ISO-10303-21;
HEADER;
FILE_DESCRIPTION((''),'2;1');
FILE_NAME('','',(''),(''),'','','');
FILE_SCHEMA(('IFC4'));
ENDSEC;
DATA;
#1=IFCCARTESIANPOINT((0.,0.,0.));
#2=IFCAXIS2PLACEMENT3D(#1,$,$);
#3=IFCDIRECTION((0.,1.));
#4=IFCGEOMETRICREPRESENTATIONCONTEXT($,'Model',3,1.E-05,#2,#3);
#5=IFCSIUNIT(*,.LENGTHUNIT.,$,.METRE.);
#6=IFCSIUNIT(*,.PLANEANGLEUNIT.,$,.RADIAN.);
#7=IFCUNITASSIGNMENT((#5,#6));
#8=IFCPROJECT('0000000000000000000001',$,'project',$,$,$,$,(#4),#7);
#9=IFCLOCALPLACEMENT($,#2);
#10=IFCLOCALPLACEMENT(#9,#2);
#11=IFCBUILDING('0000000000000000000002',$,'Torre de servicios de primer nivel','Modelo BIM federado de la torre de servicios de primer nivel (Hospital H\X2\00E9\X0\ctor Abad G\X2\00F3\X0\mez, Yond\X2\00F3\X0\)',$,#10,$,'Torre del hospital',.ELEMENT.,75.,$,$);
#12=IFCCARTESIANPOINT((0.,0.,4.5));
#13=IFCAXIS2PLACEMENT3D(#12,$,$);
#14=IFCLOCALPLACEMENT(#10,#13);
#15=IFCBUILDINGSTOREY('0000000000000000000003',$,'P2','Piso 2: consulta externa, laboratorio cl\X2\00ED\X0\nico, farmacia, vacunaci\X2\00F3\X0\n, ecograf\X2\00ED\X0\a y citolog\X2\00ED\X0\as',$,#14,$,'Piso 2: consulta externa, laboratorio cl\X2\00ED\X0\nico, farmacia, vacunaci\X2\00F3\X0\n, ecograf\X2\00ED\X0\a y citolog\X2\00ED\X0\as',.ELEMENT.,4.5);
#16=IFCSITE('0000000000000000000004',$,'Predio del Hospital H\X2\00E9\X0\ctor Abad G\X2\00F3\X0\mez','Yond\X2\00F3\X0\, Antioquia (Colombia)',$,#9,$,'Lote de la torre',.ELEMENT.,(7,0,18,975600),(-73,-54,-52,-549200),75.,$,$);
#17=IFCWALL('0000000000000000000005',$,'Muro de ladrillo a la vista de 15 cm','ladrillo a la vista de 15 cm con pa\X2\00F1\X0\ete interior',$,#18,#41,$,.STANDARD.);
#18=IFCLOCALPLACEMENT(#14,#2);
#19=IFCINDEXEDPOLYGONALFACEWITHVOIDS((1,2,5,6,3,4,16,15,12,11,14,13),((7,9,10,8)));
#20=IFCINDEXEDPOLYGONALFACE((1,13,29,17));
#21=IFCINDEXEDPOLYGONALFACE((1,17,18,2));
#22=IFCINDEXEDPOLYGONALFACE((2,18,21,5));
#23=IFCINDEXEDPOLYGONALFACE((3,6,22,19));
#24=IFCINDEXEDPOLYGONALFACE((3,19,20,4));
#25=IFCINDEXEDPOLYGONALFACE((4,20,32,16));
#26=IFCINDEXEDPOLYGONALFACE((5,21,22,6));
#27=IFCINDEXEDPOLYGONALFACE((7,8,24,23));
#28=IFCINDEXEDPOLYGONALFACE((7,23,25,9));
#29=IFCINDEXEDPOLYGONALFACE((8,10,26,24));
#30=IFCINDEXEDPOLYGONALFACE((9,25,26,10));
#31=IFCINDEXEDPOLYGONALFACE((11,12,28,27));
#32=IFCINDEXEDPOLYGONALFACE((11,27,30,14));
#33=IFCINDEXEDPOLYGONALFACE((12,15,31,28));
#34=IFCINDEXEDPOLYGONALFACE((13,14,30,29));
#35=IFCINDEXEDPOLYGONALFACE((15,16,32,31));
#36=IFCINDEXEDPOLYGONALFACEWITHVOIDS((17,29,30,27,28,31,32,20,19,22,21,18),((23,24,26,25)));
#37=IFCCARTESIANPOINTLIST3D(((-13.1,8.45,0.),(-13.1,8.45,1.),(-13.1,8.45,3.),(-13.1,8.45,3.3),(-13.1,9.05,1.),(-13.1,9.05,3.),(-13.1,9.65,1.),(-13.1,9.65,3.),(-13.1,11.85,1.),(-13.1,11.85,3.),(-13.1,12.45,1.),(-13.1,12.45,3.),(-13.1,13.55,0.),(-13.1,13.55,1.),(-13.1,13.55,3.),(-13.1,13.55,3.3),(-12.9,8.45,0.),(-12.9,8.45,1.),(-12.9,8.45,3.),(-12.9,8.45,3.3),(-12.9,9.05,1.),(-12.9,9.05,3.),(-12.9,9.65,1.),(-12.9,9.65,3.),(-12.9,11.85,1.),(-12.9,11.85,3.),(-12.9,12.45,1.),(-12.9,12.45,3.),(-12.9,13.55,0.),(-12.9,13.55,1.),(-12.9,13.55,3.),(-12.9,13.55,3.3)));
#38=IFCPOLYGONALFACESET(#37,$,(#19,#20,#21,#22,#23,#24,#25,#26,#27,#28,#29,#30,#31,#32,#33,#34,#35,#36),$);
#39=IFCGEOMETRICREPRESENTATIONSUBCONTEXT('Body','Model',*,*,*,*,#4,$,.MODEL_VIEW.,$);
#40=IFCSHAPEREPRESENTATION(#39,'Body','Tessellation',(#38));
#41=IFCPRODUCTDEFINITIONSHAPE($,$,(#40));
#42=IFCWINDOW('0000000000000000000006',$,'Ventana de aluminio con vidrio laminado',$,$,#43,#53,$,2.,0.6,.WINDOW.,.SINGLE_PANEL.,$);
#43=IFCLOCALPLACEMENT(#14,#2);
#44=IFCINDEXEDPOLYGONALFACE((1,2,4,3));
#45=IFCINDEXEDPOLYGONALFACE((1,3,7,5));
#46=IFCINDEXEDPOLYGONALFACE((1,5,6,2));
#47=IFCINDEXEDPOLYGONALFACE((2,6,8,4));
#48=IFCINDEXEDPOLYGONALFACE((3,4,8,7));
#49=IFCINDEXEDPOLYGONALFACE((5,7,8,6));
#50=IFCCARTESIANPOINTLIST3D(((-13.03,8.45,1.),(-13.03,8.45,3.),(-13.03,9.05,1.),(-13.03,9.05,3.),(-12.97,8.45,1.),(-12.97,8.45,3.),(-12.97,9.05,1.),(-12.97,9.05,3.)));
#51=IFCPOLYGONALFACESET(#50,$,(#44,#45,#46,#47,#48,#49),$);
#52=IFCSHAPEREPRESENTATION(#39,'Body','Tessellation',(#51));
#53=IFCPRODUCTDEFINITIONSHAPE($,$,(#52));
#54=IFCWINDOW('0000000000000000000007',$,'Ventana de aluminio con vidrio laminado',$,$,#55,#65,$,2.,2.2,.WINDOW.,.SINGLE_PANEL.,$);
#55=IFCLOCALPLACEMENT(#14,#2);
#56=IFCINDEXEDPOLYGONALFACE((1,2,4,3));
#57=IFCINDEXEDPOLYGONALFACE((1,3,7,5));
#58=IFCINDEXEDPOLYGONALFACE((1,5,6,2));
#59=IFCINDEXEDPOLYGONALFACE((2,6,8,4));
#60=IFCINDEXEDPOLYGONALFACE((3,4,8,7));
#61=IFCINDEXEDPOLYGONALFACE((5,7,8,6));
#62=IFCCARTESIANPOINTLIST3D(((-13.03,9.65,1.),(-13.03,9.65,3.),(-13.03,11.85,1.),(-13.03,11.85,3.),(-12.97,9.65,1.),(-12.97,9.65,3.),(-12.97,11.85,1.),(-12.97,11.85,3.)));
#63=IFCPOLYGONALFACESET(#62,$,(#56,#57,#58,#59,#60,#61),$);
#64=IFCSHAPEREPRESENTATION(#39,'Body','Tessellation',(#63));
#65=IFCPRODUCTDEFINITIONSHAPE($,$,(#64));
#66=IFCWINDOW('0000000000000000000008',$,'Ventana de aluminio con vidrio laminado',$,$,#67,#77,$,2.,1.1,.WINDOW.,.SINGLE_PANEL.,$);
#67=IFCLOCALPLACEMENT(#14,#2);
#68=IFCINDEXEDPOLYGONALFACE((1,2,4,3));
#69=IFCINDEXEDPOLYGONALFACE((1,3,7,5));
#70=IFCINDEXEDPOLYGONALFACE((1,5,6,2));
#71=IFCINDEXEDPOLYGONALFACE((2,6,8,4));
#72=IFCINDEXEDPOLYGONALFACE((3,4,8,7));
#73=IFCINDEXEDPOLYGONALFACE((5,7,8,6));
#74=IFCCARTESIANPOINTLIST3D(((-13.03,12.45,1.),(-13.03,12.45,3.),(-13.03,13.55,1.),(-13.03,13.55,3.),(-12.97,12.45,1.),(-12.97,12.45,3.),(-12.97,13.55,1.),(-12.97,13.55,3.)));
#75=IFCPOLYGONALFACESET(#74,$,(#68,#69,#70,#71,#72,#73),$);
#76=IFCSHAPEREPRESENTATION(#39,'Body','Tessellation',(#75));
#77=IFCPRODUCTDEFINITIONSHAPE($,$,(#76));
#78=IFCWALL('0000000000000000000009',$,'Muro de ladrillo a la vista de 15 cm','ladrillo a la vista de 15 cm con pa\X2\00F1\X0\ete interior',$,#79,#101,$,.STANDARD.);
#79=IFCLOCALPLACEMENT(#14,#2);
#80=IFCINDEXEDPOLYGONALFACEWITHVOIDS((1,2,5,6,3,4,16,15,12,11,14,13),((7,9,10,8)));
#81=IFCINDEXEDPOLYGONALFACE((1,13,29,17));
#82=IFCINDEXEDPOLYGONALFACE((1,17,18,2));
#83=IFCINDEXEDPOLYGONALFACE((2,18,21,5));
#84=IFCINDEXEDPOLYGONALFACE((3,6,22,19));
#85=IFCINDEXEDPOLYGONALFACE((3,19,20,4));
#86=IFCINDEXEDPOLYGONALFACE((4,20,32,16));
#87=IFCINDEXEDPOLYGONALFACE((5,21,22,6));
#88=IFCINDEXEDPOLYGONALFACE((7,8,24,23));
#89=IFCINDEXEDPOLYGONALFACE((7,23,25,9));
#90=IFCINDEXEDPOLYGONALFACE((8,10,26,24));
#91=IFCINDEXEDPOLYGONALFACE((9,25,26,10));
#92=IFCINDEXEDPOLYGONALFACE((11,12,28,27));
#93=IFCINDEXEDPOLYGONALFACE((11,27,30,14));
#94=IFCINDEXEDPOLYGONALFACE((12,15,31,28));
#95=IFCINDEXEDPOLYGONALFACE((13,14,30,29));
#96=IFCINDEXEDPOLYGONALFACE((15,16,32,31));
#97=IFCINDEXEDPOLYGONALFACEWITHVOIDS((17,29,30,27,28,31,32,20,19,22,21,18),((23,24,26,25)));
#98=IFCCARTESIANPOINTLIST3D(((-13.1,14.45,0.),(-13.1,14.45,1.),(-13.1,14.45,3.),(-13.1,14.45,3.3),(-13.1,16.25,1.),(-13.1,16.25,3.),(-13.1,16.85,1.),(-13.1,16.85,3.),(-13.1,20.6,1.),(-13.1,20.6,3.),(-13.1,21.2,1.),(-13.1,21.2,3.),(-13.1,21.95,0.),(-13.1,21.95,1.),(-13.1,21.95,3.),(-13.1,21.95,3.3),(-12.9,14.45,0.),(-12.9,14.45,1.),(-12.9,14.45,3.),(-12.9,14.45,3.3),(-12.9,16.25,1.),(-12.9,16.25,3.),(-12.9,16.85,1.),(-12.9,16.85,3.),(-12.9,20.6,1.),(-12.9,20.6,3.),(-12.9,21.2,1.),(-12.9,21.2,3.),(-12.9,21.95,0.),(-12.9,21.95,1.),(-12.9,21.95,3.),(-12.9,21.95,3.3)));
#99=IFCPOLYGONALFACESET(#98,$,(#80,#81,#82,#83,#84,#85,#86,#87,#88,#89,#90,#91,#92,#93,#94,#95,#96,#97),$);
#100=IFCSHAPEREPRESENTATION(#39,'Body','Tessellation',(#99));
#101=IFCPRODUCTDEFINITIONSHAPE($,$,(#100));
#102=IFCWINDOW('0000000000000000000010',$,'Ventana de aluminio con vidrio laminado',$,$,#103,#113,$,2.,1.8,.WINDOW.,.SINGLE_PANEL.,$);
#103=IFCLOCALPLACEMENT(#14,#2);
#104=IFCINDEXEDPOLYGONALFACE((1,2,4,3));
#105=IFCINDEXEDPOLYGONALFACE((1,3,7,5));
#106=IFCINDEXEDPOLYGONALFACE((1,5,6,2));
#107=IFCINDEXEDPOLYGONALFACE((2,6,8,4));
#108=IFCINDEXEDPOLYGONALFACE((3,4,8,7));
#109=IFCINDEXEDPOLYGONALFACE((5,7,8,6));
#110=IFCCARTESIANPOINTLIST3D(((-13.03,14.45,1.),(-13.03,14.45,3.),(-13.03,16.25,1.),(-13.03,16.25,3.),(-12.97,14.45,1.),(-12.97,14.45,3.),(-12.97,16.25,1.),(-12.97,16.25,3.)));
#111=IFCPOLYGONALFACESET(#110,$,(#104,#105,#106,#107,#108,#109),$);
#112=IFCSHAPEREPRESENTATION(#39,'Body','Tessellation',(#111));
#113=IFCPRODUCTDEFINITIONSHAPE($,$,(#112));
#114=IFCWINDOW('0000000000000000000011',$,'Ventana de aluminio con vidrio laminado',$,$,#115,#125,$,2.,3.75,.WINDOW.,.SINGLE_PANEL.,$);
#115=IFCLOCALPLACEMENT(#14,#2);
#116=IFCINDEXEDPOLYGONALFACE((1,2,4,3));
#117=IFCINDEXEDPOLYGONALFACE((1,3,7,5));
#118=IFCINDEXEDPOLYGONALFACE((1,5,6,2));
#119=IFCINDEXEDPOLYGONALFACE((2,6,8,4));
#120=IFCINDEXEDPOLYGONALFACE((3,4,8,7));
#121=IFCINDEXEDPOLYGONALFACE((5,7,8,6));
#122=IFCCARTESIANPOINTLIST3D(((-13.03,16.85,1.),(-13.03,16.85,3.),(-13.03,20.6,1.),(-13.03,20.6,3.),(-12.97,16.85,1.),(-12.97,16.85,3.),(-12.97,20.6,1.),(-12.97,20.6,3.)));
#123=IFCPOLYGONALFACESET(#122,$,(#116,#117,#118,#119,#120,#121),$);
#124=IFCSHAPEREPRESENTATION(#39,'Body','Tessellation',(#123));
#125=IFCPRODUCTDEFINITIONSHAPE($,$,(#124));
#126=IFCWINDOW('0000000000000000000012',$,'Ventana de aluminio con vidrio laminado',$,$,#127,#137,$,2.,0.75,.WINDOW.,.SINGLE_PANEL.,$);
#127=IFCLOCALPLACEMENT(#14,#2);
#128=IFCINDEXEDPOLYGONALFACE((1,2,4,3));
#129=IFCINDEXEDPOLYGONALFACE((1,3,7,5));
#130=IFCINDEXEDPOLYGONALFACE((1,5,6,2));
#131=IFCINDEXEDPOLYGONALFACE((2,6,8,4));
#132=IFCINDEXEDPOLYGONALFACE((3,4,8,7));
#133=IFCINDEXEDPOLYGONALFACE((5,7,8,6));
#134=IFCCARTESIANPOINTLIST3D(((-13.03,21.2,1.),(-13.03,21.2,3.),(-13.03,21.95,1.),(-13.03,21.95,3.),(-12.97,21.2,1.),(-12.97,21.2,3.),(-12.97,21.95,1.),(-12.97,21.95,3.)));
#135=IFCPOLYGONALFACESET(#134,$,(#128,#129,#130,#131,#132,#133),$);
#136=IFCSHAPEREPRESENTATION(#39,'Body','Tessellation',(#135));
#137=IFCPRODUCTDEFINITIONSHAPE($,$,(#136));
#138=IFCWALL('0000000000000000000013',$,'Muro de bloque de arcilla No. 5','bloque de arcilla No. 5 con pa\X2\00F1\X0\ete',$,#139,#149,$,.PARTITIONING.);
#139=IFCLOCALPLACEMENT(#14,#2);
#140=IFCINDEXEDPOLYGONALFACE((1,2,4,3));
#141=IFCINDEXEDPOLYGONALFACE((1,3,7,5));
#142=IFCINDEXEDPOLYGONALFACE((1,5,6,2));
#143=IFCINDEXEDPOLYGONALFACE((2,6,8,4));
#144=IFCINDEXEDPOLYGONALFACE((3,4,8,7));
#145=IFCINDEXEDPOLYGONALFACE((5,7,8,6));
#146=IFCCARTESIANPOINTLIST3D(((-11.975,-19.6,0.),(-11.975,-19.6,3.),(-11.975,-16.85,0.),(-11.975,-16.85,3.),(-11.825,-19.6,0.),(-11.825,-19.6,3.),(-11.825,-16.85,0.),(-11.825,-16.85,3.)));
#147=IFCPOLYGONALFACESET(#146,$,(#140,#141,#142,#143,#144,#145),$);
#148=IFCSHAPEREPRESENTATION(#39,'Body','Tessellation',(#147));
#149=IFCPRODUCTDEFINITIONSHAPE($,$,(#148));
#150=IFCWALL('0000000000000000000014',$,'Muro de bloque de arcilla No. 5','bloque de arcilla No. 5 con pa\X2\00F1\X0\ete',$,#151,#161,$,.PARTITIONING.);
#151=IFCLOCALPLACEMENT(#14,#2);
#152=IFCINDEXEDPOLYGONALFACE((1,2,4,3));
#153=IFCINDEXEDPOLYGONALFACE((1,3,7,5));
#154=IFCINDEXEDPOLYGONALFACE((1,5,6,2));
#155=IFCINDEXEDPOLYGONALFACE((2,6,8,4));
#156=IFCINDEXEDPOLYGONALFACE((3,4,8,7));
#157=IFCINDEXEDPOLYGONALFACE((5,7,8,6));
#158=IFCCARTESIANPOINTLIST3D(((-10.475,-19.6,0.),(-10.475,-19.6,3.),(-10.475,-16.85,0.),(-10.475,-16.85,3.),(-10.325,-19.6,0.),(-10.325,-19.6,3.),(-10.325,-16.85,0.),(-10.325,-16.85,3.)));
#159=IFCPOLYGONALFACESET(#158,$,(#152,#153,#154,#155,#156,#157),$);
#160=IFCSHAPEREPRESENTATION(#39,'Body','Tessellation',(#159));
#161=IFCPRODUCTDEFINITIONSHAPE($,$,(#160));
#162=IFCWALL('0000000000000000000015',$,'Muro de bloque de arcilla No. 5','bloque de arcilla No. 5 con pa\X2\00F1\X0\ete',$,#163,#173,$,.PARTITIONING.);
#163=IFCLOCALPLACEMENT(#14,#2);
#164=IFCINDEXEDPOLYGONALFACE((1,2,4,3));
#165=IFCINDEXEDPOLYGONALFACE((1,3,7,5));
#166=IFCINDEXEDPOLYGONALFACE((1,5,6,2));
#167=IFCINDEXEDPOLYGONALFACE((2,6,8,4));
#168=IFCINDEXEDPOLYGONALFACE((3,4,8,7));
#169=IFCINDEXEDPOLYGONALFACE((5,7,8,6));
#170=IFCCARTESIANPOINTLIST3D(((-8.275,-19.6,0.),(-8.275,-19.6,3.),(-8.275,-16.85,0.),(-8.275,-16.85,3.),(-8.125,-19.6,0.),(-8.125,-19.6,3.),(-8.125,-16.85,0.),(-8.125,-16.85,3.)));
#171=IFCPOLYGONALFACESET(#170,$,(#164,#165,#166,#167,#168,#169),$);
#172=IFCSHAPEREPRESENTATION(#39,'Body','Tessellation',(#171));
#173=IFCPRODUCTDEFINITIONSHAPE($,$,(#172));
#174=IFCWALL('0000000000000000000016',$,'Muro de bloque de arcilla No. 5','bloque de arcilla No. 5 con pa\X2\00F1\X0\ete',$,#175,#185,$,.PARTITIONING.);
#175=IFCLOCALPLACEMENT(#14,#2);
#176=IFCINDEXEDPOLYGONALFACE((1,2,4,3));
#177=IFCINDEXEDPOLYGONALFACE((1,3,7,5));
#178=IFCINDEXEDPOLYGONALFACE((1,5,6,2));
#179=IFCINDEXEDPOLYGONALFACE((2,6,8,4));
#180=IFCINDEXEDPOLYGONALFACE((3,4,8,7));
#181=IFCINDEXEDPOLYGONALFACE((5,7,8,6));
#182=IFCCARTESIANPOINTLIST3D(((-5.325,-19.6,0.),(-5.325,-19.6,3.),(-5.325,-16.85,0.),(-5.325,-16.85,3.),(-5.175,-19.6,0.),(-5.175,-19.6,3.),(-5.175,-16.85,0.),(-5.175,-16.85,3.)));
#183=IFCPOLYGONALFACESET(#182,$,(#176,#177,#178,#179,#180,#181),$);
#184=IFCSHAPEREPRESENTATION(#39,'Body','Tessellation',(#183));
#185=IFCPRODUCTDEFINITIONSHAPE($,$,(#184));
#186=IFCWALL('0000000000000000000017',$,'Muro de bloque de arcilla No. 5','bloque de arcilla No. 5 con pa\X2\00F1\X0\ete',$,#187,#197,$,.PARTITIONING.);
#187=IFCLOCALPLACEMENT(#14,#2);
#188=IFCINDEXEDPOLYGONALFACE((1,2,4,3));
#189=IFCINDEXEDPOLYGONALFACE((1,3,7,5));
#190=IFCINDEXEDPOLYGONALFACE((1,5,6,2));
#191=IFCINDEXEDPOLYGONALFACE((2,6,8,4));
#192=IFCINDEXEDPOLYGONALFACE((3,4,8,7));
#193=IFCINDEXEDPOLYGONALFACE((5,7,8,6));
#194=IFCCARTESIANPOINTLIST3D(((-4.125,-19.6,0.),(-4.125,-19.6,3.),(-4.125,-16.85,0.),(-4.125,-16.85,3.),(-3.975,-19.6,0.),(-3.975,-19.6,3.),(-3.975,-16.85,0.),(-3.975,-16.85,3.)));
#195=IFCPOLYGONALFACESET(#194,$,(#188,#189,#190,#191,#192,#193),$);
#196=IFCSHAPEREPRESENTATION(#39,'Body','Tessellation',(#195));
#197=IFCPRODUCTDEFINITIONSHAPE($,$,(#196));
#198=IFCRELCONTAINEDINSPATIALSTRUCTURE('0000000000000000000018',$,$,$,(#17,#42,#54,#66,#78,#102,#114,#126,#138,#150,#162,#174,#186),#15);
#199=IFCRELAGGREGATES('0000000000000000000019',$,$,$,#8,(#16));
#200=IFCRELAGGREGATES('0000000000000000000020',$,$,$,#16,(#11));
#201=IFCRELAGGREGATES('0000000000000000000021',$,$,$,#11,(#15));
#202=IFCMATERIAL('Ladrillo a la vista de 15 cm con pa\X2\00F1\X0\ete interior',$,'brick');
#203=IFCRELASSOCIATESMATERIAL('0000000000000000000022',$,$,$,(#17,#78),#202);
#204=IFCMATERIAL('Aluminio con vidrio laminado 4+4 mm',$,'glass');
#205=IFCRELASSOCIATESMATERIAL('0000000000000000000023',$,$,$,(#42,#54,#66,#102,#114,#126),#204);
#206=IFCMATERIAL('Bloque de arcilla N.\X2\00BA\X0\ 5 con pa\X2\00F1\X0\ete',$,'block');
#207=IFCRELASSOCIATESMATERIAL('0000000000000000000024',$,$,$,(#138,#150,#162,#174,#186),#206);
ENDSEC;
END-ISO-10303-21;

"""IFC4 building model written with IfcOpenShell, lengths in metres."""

from ifc_helpers import new_model, si_unit, direction, frame, origin, place, context, subcontext, project, spatial, rectangle, extrude, material, element, fill, save


model = new_model("IFC4")

# Units and contexts
model_context = context("Model", 3, precision=1e-05, world=origin(), true_north=direction((0.0, 1.0)))
body_context = subcontext(model_context, "Body", "Model", "MODEL_VIEW")
ifc_project = project(units=[si_unit("LENGTHUNIT", "METRE"), si_unit("PLANEANGLEUNIT", "RADIAN")], contexts=[model_context])

# Site, building, storey
site_placement = place(None, origin())
site = spatial("IfcSite", under=ifc_project, at=site_placement, Name="Predio del Hospital Héctor Abad Gómez", Description="Yondó, Antioquia (Colombia)", LongName="Lote de la torre", CompositionType="ELEMENT", RefLatitude=(7, 0, 18, 975600), RefLongitude=(-73, -54, -52, -549200), RefElevation=75.0)
building_placement = place(site_placement, origin())
building = spatial("IfcBuilding", under=site, at=building_placement, Name="Torre de servicios de primer nivel", Description="Modelo BIM federado de la torre de servicios de primer nivel (Hospital Héctor Abad Gómez, Yondó)", LongName="Torre del hospital", CompositionType="ELEMENT", ElevationOfRefHeight=75.0)
placement = place(building_placement, frame((0.0, 0.0, 4.5)))
storey = spatial("IfcBuildingStorey", under=building, at=placement, Name="P2", Description="Piso 2: consulta externa, laboratorio clínico, farmacia, vacunación, ecografía y citologías", LongName="Piso 2: consulta externa, laboratorio clínico, farmacia, vacunación, ecografía y citologías", CompositionType="ELEMENT", Elevation=4.5)

# Walls, openings, windows
ifc_material_1 = material(Name="Ladrillo a la vista de 15 cm con pañete interior", Category="brick")
wall_1 = element("IfcWall", 1, at=placement, inside=storey, material=ifc_material_1, Name="Muro de ladrillo a la vista de 15 cm", Description="ladrillo a la vista de 15 cm con pañete interior", PredefinedType="STANDARD", context=body_context, shape_type="SweptSolid", body=[
    extrude(rectangle(XDim=0.2, YDim=5.1), frame((-13.0, 11.0, 0.0)), (0.0, 0.0, 1.0), 3.3),
])
opening_1 = element("IfcOpeningElement", 2, at=placement, cuts=wall_1, PredefinedType="OPENING", context=body_context, shape_type="SweptSolid", body=[
    extrude(rectangle(XDim=0.3, YDim=0.6), frame((-13.0, 8.75, 1.0)), (0.0, 0.0, 1.0), 2.0),
])
opening_2 = element("IfcOpeningElement", 3, at=placement, cuts=wall_1, PredefinedType="OPENING", context=body_context, shape_type="SweptSolid", body=[
    extrude(rectangle(XDim=0.3, YDim=2.2), frame((-13.0, 10.75, 1.0)), (0.0, 0.0, 1.0), 2.0),
])
opening_3 = element("IfcOpeningElement", 4, at=placement, cuts=wall_1, PredefinedType="OPENING", context=body_context, shape_type="SweptSolid", body=[
    extrude(rectangle(XDim=0.3, YDim=1.1), frame((-13.0, 13.0, 1.0)), (0.0, 0.0, 1.0), 2.0),
])
ifc_material_2 = material(Name="Aluminio con vidrio laminado 4+4 mm", Category="glass")
window_1 = element("IfcWindow", 5, at=placement, inside=storey, material=ifc_material_2, Name="Ventana de aluminio con vidrio laminado", OverallHeight=2.0, OverallWidth=0.6, PartitioningType="SINGLE_PANEL", PredefinedType="WINDOW", context=body_context, shape_type="SweptSolid", body=[
    extrude(rectangle(XDim=0.06, YDim=0.6), frame((-13.0, 8.75, 1.0)), (0.0, 0.0, 1.0), 2.0),
])
fill(opening_1, window_1)
window_2 = element("IfcWindow", 6, at=placement, inside=storey, material=ifc_material_2, Name="Ventana de aluminio con vidrio laminado", OverallHeight=2.0, OverallWidth=2.2, PartitioningType="SINGLE_PANEL", PredefinedType="WINDOW", context=body_context, shape_type="SweptSolid", body=[
    extrude(rectangle(XDim=0.06, YDim=2.2), frame((-13.0, 10.75, 1.0)), (0.0, 0.0, 1.0), 2.0),
])
fill(opening_2, window_2)
window_3 = element("IfcWindow", 7, at=placement, inside=storey, material=ifc_material_2, Name="Ventana de aluminio con vidrio laminado", OverallHeight=2.0, OverallWidth=1.1, PartitioningType="SINGLE_PANEL", PredefinedType="WINDOW", context=body_context, shape_type="SweptSolid", body=[
    extrude(rectangle(XDim=0.06, YDim=1.1), frame((-13.0, 13.0, 1.0)), (0.0, 0.0, 1.0), 2.0),
])
fill(opening_3, window_3)
wall_2 = element("IfcWall", 8, at=placement, inside=storey, material=ifc_material_1, Name="Muro de ladrillo a la vista de 15 cm", Description="ladrillo a la vista de 15 cm con pañete interior", PredefinedType="STANDARD", context=body_context, shape_type="SweptSolid", body=[
    extrude(rectangle(XDim=0.2, YDim=7.5), frame((-13.0, 18.2, 0.0)), (0.0, 0.0, 1.0), 3.3),
])
opening_4 = element("IfcOpeningElement", 9, at=placement, cuts=wall_2, PredefinedType="OPENING", context=body_context, shape_type="SweptSolid", body=[
    extrude(rectangle(XDim=0.3, YDim=1.8), frame((-13.0, 15.35, 1.0)), (0.0, 0.0, 1.0), 2.0),
])
opening_5 = element("IfcOpeningElement", 10, at=placement, cuts=wall_2, PredefinedType="OPENING", context=body_context, shape_type="SweptSolid", body=[
    extrude(rectangle(XDim=0.3, YDim=3.75), frame((-13.0, 18.725, 1.0)), (0.0, 0.0, 1.0), 2.0),
])
opening_6 = element("IfcOpeningElement", 11, at=placement, cuts=wall_2, PredefinedType="OPENING", context=body_context, shape_type="SweptSolid", body=[
    extrude(rectangle(XDim=0.3, YDim=0.75), frame((-13.0, 21.575, 1.0)), (0.0, 0.0, 1.0), 2.0),
])
window_4 = element("IfcWindow", 12, at=placement, inside=storey, material=ifc_material_2, Name="Ventana de aluminio con vidrio laminado", OverallHeight=2.0, OverallWidth=1.8, PartitioningType="SINGLE_PANEL", PredefinedType="WINDOW", context=body_context, shape_type="SweptSolid", body=[
    extrude(rectangle(XDim=0.06, YDim=1.8), frame((-13.0, 15.35, 1.0)), (0.0, 0.0, 1.0), 2.0),
])
fill(opening_4, window_4)
window_5 = element("IfcWindow", 13, at=placement, inside=storey, material=ifc_material_2, Name="Ventana de aluminio con vidrio laminado", OverallHeight=2.0, OverallWidth=3.75, PartitioningType="SINGLE_PANEL", PredefinedType="WINDOW", context=body_context, shape_type="SweptSolid", body=[
    extrude(rectangle(XDim=0.06, YDim=3.75), frame((-13.0, 18.725, 1.0)), (0.0, 0.0, 1.0), 2.0),
])
fill(opening_5, window_5)
window_6 = element("IfcWindow", 14, at=placement, inside=storey, material=ifc_material_2, Name="Ventana de aluminio con vidrio laminado", OverallHeight=2.0, OverallWidth=0.75, PartitioningType="SINGLE_PANEL", PredefinedType="WINDOW", context=body_context, shape_type="SweptSolid", body=[
    extrude(rectangle(XDim=0.06, YDim=0.75), frame((-13.0, 21.575, 1.0)), (0.0, 0.0, 1.0), 2.0),
])
fill(opening_6, window_6)

# Walls
ifc_material_3 = material(Name="Bloque de arcilla N.º 5 con pañete", Category="block")
element("IfcWall", 15, at=placement, inside=storey, material=ifc_material_3, Name="Muro de bloque de arcilla No. 5", Description="bloque de arcilla No. 5 con pañete", PredefinedType="PARTITIONING", context=body_context, shape_type="SweptSolid", body=[
    extrude(rectangle(XDim=0.15, YDim=2.75), frame((-11.9, -18.225, 0.0)), (0.0, 0.0, 1.0), 3.0),
])
element("IfcWall", 16, at=placement, inside=storey, material=ifc_material_3, Name="Muro de bloque de arcilla No. 5", Description="bloque de arcilla No. 5 con pañete", PredefinedType="PARTITIONING", context=body_context, shape_type="SweptSolid", body=[
    extrude(rectangle(XDim=0.15, YDim=2.75), frame((-10.4, -18.225, 0.0)), (0.0, 0.0, 1.0), 3.0),
])
element("IfcWall", 17, at=placement, inside=storey, material=ifc_material_3, Name="Muro de bloque de arcilla No. 5", Description="bloque de arcilla No. 5 con pañete", PredefinedType="PARTITIONING", context=body_context, shape_type="SweptSolid", body=[
    extrude(rectangle(XDim=0.15, YDim=2.75), frame((-8.2, -18.225, 0.0)), (0.0, 0.0, 1.0), 3.0),
])
element("IfcWall", 18, at=placement, inside=storey, material=ifc_material_3, Name="Muro de bloque de arcilla No. 5", Description="bloque de arcilla No. 5 con pañete", PredefinedType="PARTITIONING", context=body_context, shape_type="SweptSolid", body=[
    extrude(rectangle(XDim=0.15, YDim=2.75), frame((-5.25, -18.225, 0.0)), (0.0, 0.0, 1.0), 3.0),
])
element("IfcWall", 19, at=placement, inside=storey, material=ifc_material_3, Name="Muro de bloque de arcilla No. 5", Description="bloque de arcilla No. 5 con pañete", PredefinedType="PARTITIONING", context=body_context, shape_type="SweptSolid", body=[
    extrude(rectangle(XDim=0.15, YDim=2.75), frame((-4.05, -18.225, 0.0)), (0.0, 0.0, 1.0), 3.0),
])

save(model, "model.ifc")
